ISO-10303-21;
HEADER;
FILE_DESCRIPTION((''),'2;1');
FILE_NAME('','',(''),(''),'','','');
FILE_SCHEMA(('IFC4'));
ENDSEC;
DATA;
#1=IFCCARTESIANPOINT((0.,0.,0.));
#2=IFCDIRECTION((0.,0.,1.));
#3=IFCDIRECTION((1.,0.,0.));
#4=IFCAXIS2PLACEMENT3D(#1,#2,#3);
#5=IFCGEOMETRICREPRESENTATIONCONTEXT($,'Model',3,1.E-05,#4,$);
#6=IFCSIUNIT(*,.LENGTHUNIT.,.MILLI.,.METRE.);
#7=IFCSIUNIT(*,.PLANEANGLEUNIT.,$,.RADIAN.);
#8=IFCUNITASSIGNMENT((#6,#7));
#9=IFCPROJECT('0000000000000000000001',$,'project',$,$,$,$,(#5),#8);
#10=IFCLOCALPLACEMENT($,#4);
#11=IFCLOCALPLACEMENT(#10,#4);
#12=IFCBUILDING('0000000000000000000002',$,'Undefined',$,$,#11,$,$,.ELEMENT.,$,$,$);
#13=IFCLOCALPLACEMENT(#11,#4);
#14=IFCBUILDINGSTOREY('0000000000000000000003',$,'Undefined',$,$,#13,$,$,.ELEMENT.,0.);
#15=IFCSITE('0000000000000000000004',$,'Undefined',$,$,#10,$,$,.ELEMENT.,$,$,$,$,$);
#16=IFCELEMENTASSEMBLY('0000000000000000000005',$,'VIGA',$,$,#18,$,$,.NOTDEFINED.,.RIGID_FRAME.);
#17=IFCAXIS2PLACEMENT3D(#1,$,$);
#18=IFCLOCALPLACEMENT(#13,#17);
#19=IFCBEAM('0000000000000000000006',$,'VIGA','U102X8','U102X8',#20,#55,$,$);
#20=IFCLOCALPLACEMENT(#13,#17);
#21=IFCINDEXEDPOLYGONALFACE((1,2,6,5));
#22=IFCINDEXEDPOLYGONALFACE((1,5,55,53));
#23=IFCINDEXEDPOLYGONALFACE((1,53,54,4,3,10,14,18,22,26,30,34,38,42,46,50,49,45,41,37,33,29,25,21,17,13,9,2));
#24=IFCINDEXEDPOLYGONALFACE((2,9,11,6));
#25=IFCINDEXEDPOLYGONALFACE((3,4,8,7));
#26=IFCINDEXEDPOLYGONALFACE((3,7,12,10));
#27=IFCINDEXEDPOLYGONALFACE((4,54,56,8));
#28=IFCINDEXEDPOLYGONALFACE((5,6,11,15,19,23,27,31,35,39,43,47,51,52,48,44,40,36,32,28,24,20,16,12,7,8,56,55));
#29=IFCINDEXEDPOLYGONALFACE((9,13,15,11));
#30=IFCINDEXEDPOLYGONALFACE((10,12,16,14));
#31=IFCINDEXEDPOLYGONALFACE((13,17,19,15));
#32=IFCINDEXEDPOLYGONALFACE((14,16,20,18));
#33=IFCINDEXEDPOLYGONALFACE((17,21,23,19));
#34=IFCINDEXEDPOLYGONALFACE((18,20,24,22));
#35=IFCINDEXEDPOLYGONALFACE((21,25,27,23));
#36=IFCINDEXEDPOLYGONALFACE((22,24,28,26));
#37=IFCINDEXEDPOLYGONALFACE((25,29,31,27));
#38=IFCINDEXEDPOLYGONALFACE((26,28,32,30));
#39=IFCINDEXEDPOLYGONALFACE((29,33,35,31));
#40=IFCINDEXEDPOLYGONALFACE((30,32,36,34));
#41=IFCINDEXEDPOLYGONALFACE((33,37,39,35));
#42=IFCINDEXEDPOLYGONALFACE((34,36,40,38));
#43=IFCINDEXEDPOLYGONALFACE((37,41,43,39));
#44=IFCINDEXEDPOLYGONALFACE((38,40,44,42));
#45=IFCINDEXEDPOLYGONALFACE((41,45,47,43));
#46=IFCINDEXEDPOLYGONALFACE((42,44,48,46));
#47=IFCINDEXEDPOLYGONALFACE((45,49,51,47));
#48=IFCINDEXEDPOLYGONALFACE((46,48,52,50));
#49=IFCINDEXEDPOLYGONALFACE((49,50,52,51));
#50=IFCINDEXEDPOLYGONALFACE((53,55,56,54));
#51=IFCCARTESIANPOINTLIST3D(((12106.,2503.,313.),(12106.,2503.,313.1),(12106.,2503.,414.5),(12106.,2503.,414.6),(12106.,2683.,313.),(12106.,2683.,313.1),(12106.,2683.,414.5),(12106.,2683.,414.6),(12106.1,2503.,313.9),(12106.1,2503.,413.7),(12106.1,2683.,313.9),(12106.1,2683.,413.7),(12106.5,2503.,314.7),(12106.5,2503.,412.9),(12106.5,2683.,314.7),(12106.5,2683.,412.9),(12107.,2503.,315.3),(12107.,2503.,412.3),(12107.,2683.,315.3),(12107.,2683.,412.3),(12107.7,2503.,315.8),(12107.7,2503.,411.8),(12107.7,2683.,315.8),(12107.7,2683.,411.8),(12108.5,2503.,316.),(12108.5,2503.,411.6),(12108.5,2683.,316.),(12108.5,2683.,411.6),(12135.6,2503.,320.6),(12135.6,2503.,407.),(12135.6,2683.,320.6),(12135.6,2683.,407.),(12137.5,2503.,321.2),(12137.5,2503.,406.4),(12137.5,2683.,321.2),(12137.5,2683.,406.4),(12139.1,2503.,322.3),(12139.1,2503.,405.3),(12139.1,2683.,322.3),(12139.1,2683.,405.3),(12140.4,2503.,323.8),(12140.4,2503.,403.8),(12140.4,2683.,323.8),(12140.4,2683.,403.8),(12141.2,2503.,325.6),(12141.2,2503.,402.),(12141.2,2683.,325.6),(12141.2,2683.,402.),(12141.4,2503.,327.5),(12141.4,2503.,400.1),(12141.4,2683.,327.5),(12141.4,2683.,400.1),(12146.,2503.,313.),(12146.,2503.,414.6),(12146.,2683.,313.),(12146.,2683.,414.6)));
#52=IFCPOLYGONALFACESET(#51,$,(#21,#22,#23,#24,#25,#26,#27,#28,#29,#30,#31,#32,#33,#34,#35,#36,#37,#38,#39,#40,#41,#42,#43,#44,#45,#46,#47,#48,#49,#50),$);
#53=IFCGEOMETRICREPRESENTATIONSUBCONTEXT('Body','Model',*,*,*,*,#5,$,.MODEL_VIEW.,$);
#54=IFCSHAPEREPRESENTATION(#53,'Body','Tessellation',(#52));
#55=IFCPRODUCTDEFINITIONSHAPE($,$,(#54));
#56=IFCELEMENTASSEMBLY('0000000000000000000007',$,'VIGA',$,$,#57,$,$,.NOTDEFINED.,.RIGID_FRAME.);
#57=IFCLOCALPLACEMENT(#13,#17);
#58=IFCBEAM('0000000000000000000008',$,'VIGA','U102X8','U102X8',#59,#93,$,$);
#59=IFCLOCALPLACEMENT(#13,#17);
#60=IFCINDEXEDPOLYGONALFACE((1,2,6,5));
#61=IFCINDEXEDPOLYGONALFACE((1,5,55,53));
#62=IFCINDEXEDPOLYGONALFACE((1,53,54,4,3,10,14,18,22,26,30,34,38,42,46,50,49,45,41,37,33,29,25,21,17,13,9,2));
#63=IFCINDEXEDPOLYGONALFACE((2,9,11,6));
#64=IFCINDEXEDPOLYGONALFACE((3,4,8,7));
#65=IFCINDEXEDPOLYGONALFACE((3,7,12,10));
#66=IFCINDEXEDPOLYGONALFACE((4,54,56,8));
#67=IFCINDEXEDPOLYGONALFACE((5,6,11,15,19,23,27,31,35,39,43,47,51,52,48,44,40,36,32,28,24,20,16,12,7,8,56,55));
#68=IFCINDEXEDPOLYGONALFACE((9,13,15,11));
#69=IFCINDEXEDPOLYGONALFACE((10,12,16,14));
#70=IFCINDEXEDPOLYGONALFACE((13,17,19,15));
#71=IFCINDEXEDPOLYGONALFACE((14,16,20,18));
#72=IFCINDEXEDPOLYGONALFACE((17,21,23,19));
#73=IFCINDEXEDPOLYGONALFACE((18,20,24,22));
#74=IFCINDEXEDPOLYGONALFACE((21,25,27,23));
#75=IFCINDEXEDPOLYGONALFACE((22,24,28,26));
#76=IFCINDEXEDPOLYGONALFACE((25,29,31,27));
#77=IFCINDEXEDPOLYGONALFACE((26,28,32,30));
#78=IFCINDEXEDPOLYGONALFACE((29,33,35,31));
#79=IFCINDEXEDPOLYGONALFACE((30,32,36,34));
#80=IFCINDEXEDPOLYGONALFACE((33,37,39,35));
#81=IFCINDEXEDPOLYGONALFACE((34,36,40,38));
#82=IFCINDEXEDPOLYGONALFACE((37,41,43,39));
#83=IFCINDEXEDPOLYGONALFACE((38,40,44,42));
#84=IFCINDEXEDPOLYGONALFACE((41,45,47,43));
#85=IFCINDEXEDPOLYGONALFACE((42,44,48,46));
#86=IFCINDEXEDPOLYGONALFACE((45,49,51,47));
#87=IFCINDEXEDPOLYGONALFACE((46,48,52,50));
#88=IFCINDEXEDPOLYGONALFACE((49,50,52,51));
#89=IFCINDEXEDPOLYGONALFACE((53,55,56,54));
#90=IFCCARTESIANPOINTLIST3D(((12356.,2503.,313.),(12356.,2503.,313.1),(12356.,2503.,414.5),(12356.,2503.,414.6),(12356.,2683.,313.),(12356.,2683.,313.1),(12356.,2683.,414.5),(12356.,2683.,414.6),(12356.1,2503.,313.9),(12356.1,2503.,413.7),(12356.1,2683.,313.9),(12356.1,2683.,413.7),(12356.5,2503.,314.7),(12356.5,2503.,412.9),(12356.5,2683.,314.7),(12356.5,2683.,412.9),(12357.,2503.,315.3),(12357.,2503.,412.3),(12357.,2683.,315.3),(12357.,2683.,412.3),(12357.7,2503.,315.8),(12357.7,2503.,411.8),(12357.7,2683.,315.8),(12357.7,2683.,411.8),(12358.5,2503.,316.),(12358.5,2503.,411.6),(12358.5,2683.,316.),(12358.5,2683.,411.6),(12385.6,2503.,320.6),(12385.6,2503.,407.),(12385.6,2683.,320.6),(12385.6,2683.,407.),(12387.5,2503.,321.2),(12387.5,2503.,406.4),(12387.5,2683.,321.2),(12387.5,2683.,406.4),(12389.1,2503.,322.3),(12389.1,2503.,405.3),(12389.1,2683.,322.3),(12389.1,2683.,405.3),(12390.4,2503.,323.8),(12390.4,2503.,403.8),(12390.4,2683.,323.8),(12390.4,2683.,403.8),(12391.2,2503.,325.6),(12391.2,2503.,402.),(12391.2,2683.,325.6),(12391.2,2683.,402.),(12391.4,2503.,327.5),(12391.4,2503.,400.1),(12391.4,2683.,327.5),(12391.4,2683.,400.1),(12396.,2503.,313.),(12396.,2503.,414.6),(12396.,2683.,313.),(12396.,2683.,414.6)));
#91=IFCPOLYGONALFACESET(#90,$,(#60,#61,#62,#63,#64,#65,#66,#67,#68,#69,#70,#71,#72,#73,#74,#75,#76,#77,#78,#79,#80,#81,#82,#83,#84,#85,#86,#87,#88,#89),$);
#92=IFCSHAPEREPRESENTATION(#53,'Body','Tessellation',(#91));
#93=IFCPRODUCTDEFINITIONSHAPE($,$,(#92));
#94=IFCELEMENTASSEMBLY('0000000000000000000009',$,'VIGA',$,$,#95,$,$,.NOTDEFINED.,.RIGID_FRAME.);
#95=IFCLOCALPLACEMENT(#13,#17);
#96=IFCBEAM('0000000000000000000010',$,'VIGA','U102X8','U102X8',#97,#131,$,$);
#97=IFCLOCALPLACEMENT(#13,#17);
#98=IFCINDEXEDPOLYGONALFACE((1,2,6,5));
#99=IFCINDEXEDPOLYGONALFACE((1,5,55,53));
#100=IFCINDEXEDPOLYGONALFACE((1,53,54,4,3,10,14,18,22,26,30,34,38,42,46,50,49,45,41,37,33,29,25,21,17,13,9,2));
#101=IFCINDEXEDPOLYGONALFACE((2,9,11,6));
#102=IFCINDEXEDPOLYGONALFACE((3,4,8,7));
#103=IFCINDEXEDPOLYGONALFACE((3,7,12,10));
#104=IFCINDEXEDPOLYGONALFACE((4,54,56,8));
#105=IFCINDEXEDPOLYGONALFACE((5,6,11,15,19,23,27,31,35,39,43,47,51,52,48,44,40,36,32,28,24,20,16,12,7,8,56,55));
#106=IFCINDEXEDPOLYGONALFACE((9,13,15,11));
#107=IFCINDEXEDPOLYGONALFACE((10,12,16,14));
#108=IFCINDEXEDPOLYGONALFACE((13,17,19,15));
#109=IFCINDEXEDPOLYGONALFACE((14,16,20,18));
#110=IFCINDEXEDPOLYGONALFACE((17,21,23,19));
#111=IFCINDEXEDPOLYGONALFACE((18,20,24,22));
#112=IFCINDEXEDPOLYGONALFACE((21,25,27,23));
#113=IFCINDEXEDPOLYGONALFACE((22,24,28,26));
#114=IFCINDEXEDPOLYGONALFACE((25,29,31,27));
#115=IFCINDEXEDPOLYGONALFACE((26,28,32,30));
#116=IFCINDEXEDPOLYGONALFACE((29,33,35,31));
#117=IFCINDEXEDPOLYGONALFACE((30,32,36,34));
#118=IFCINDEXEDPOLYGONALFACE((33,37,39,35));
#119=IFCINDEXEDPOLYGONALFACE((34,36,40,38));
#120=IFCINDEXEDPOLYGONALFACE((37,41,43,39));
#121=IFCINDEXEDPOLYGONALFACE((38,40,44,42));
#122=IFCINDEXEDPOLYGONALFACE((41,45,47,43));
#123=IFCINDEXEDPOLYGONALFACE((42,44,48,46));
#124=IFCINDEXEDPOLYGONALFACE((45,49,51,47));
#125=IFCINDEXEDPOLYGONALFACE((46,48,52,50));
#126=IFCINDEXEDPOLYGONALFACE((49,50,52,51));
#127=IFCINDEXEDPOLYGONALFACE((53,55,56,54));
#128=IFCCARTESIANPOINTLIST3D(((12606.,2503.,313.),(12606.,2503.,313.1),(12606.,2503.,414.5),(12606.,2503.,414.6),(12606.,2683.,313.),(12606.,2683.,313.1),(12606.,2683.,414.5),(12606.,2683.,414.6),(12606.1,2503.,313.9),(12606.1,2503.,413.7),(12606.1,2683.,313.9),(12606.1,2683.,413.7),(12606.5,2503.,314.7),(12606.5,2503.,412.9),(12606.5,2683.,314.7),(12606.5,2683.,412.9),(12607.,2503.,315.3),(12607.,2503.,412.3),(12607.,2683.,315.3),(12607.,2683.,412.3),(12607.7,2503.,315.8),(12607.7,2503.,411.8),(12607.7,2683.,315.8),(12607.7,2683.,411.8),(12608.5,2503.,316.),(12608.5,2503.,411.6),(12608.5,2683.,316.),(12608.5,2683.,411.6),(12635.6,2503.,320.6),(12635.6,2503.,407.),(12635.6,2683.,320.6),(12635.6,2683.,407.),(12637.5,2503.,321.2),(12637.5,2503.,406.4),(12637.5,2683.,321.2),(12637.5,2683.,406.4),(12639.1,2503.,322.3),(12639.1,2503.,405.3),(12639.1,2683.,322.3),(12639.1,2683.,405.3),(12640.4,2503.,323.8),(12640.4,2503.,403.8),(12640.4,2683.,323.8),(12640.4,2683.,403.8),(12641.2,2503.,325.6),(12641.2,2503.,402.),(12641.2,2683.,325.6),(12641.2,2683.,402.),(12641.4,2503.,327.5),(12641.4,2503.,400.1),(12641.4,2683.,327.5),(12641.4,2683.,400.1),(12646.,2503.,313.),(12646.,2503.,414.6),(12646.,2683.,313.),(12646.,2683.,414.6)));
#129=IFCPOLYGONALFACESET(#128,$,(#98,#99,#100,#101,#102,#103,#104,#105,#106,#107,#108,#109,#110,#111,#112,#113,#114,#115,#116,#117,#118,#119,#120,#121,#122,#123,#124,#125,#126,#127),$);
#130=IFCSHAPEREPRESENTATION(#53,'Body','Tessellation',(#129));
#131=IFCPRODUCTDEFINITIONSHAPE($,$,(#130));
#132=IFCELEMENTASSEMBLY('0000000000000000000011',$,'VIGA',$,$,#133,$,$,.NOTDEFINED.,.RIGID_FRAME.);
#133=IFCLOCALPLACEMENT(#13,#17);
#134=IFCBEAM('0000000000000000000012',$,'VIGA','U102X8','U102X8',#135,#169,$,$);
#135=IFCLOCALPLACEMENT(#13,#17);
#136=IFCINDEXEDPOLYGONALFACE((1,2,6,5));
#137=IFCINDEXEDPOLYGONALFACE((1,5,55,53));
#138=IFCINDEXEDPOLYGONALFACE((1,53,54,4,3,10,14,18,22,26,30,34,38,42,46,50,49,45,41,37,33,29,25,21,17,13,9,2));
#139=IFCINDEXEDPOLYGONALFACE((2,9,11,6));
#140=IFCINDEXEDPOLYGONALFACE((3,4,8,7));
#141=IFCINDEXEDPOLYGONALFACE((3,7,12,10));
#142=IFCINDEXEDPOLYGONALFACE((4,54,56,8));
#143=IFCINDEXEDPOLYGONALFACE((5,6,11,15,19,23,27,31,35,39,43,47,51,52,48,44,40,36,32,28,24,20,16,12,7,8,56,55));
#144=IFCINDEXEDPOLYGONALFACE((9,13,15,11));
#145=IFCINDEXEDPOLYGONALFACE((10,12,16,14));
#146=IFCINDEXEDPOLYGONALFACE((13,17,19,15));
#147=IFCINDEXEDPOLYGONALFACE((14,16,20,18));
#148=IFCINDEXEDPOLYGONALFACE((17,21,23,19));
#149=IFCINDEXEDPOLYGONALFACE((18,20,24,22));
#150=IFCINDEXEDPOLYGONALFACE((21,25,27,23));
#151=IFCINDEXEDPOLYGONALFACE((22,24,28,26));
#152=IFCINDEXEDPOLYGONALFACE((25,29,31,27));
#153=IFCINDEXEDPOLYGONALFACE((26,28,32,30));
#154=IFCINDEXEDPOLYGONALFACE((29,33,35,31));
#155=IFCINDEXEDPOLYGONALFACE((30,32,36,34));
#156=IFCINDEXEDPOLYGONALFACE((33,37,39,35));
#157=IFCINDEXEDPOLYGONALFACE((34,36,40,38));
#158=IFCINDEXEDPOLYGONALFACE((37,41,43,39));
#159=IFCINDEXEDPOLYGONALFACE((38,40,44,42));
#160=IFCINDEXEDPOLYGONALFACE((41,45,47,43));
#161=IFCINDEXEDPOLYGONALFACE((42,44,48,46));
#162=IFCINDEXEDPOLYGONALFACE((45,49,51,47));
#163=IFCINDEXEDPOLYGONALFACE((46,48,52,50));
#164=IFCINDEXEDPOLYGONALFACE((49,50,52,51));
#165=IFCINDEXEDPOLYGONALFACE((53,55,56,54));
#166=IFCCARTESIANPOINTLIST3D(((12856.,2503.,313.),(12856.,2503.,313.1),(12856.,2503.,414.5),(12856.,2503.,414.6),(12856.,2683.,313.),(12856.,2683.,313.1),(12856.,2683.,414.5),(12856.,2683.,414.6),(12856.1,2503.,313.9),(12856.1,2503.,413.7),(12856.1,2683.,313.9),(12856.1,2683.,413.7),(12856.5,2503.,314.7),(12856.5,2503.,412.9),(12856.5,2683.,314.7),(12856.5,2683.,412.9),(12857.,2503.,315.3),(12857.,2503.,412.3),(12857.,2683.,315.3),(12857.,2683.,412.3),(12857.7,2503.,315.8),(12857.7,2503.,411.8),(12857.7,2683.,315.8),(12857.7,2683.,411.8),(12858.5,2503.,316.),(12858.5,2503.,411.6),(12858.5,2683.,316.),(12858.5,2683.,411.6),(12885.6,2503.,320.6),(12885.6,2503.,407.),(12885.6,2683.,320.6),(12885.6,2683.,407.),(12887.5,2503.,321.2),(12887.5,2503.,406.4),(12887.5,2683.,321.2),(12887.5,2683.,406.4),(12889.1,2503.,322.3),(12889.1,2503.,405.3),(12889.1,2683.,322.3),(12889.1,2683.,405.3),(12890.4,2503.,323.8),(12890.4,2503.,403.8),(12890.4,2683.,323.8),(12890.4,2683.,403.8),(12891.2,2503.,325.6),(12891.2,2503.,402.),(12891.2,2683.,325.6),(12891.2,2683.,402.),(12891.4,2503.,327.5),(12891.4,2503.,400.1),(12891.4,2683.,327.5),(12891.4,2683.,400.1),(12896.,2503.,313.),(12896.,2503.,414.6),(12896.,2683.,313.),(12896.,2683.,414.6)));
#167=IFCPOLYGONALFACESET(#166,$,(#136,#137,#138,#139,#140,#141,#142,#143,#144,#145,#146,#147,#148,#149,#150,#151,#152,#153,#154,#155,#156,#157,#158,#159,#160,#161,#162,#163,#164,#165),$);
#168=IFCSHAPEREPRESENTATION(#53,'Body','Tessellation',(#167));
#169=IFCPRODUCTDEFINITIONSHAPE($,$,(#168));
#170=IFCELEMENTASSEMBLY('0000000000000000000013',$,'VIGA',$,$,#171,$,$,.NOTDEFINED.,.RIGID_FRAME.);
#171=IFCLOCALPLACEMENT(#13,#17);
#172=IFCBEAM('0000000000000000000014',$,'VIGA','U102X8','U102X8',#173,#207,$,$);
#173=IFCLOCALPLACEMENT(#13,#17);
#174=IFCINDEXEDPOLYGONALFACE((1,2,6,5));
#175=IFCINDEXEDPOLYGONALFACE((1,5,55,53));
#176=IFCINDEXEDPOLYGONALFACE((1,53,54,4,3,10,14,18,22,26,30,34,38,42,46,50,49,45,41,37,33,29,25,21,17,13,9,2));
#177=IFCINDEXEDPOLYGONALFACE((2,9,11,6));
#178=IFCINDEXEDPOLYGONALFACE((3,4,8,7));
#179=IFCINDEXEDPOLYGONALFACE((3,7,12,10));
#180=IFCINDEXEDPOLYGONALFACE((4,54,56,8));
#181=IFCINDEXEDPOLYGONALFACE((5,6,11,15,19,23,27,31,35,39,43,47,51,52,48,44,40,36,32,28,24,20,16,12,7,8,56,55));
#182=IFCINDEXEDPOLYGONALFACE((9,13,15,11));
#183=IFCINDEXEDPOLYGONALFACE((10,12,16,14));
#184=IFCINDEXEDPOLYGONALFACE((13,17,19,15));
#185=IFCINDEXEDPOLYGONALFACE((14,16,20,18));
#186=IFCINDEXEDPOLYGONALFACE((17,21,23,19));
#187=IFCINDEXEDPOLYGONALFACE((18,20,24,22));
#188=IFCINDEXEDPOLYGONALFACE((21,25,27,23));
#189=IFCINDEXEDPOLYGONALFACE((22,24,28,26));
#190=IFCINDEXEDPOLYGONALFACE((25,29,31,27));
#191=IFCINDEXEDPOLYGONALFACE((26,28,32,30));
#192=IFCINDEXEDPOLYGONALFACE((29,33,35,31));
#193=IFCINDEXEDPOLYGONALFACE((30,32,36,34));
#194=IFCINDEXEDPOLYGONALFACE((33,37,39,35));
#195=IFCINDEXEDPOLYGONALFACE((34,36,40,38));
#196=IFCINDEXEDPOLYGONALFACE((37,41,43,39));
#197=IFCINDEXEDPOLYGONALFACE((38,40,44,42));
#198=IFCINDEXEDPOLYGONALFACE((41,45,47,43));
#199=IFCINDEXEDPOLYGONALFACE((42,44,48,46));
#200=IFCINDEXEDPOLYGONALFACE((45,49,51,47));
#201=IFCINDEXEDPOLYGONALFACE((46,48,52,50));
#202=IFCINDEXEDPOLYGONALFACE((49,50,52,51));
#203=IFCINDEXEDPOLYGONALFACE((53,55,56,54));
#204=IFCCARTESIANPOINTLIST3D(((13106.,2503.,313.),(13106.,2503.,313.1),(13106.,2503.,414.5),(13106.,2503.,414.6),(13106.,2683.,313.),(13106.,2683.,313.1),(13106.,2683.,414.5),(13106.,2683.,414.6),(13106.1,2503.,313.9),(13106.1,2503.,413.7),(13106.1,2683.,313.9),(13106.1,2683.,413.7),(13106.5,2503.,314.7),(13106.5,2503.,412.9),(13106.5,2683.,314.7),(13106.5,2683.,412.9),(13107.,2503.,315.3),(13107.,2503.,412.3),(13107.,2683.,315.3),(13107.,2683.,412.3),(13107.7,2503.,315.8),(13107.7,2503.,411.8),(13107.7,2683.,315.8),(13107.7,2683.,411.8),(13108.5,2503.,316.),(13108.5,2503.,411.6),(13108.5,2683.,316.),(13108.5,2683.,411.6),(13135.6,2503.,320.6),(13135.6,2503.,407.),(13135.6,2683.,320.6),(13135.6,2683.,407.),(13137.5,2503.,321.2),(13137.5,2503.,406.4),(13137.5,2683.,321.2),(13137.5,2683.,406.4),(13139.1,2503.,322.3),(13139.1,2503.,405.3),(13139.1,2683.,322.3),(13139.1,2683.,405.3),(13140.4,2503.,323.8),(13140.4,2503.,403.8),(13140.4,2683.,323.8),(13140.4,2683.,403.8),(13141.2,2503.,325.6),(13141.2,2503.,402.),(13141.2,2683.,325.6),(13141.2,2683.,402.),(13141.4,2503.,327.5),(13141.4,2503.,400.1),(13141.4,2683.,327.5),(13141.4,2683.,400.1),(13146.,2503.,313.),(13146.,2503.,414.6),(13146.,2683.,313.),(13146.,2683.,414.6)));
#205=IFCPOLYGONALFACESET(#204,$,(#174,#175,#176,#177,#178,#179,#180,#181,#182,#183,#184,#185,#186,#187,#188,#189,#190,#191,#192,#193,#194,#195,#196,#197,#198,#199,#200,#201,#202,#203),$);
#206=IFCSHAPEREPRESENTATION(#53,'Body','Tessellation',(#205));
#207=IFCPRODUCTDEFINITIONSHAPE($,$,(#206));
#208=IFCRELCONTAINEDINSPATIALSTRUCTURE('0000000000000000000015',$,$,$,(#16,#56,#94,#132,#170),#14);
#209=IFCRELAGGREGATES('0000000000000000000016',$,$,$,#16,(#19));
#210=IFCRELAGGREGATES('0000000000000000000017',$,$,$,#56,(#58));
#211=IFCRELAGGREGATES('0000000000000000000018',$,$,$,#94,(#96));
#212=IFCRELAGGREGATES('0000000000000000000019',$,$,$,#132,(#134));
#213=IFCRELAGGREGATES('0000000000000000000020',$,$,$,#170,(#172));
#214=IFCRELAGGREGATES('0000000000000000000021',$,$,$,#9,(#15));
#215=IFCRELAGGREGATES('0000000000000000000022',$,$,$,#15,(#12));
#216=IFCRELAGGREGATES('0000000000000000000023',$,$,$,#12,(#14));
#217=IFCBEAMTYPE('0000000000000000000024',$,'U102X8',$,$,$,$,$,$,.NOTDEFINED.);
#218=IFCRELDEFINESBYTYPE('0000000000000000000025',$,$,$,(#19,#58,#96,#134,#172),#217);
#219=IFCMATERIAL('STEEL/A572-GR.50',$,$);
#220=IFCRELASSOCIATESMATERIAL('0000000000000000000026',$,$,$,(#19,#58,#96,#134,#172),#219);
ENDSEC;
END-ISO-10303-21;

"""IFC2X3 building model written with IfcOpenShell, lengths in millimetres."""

from ifc_helpers import new_model, si_unit, frame, origin_with_axes, origin_2d_with_axis, place, context, subcontext, project, spatial, u_section, extrude, material, type_object, element, aggregate, save


model = new_model("IFC2X3")

# Units and contexts
model_context = context("Model", 3, precision=1e-05, world=origin_with_axes())
body_context = subcontext(model_context, "Body", "Model", "MODEL_VIEW")
ifc_project = project(units=[si_unit("LENGTHUNIT", "METRE", prefix="MILLI"), si_unit("PLANEANGLEUNIT", "RADIAN")], contexts=[model_context])

# Site, building, storey
site_placement = place(None, origin_with_axes())
site = spatial("IfcSite", under=ifc_project, at=site_placement, Name="Undefined", CompositionType="ELEMENT")
building_placement = place(site_placement, origin_with_axes())
building = spatial("IfcBuilding", under=site, at=building_placement, Name="Undefined", CompositionType="ELEMENT")
storey_placement = place(building_placement, origin_with_axes())
storey = spatial("IfcBuildingStorey", under=building, at=storey_placement, Name="Undefined", CompositionType="ELEMENT", Elevation=0.0)

# Element assemblies, beams
ifc_material = material(Name="STEEL/A572-GR.50")
beam_type = type_object("IfcBeamType", Name="U102X8", PredefinedType="NOTDEFINED")
assembly_1_placement = place(storey_placement, origin_with_axes())
assembly_1 = element("IfcElementAssembly", 1, at=assembly_1_placement, inside=storey, Name="VIGA", AssemblyPlace="NOTDEFINED", PredefinedType="RIGID_FRAME")
beam_1_placement = place(assembly_1_placement, frame((12126.0, 2683.0, 363.8), z_axis=(0.0, 0.0, 1.0), x_axis=(0.0, -1.0, 0.0)))
beam_1 = element("IfcBeam", 2, at=beam_1_placement, type_object=beam_type, material=ifc_material, Name="VIGA", Description="U102X8", ObjectType="U102X8", context=body_context, shape_type="SweptSolid", body=[
    extrude(u_section(Depth=101.6, FlangeWidth=40.0, WebThickness=4.6, FlangeThickness=6.0, FilletRadius=7.0, EdgeRadius=3.0, FlangeSlope=0.16839, at=origin_2d_with_axis()), frame((180.0, 0.0, 0.0), z_axis=(-1.0, 0.0, 0.0), x_axis=(0.0, -1.0, 0.0)), (0.0, 0.0, 1.0), 180.0),
])
aggregate(assembly_1, [beam_1])
assembly_2_placement = place(storey_placement, origin_with_axes())
assembly_2 = element("IfcElementAssembly", 3, at=assembly_2_placement, inside=storey, Name="VIGA", AssemblyPlace="NOTDEFINED", PredefinedType="RIGID_FRAME")
beam_2_placement = place(assembly_2_placement, frame((12376.0, 2683.0, 363.8), z_axis=(0.0, 0.0, 1.0), x_axis=(0.0, -1.0, 0.0)))
beam_2 = element("IfcBeam", 4, at=beam_2_placement, type_object=beam_type, material=ifc_material, Name="VIGA", Description="U102X8", ObjectType="U102X8", context=body_context, shape_type="SweptSolid", body=[
    extrude(u_section(Depth=101.6, FlangeWidth=40.0, WebThickness=4.6, FlangeThickness=6.0, FilletRadius=7.0, EdgeRadius=3.0, FlangeSlope=0.16839, at=origin_2d_with_axis()), frame((180.0, 0.0, 0.0), z_axis=(-1.0, 0.0, 0.0), x_axis=(0.0, -1.0, 0.0)), (0.0, 0.0, 1.0), 180.0),
])
aggregate(assembly_2, [beam_2])
assembly_3_placement = place(storey_placement, origin_with_axes())
assembly_3 = element("IfcElementAssembly", 5, at=assembly_3_placement, inside=storey, Name="VIGA", AssemblyPlace="NOTDEFINED", PredefinedType="RIGID_FRAME")
beam_3_placement = place(assembly_3_placement, frame((12626.0, 2683.0, 363.8), z_axis=(0.0, 0.0, 1.0), x_axis=(0.0, -1.0, 0.0)))
beam_3 = element("IfcBeam", 6, at=beam_3_placement, type_object=beam_type, material=ifc_material, Name="VIGA", Description="U102X8", ObjectType="U102X8", context=body_context, shape_type="SweptSolid", body=[
    extrude(u_section(Depth=101.6, FlangeWidth=40.0, WebThickness=4.6, FlangeThickness=6.0, FilletRadius=7.0, EdgeRadius=3.0, FlangeSlope=0.16839, at=origin_2d_with_axis()), frame((180.0, 0.0, 0.0), z_axis=(-1.0, 0.0, 0.0), x_axis=(0.0, -1.0, 0.0)), (0.0, 0.0, 1.0), 180.0),
])
aggregate(assembly_3, [beam_3])
assembly_4_placement = place(storey_placement, origin_with_axes())
assembly_4 = element("IfcElementAssembly", 7, at=assembly_4_placement, inside=storey, Name="VIGA", AssemblyPlace="NOTDEFINED", PredefinedType="RIGID_FRAME")
beam_4_placement = place(assembly_4_placement, frame((12876.0, 2683.0, 363.8), z_axis=(0.0, 0.0, 1.0), x_axis=(0.0, -1.0, 0.0)))
beam_4 = element("IfcBeam", 8, at=beam_4_placement, type_object=beam_type, material=ifc_material, Name="VIGA", Description="U102X8", ObjectType="U102X8", context=body_context, shape_type="SweptSolid", body=[
    extrude(u_section(Depth=101.6, FlangeWidth=40.0, WebThickness=4.6, FlangeThickness=6.0, FilletRadius=7.0, EdgeRadius=3.0, FlangeSlope=0.16839, at=origin_2d_with_axis()), frame((180.0, 0.0, 0.0), z_axis=(-1.0, 0.0, 0.0), x_axis=(0.0, -1.0, 0.0)), (0.0, 0.0, 1.0), 180.0),
])
aggregate(assembly_4, [beam_4])
assembly_5_placement = place(storey_placement, origin_with_axes())
assembly_5 = element("IfcElementAssembly", 9, at=assembly_5_placement, inside=storey, Name="VIGA", AssemblyPlace="NOTDEFINED", PredefinedType="RIGID_FRAME")
beam_5_placement = place(assembly_5_placement, frame((13126.0, 2683.0, 363.8), z_axis=(0.0, 0.0, 1.0), x_axis=(0.0, -1.0, 0.0)))
beam_5 = element("IfcBeam", 10, at=beam_5_placement, type_object=beam_type, material=ifc_material, Name="VIGA", Description="U102X8", ObjectType="U102X8", context=body_context, shape_type="SweptSolid", body=[
    extrude(u_section(Depth=101.6, FlangeWidth=40.0, WebThickness=4.6, FlangeThickness=6.0, FilletRadius=7.0, EdgeRadius=3.0, FlangeSlope=0.16839, at=origin_2d_with_axis()), frame((180.0, 0.0, 0.0), z_axis=(-1.0, 0.0, 0.0), x_axis=(0.0, -1.0, 0.0)), (0.0, 0.0, 1.0), 180.0),
])
aggregate(assembly_5, [beam_5])

save(model, "model.ifc")
